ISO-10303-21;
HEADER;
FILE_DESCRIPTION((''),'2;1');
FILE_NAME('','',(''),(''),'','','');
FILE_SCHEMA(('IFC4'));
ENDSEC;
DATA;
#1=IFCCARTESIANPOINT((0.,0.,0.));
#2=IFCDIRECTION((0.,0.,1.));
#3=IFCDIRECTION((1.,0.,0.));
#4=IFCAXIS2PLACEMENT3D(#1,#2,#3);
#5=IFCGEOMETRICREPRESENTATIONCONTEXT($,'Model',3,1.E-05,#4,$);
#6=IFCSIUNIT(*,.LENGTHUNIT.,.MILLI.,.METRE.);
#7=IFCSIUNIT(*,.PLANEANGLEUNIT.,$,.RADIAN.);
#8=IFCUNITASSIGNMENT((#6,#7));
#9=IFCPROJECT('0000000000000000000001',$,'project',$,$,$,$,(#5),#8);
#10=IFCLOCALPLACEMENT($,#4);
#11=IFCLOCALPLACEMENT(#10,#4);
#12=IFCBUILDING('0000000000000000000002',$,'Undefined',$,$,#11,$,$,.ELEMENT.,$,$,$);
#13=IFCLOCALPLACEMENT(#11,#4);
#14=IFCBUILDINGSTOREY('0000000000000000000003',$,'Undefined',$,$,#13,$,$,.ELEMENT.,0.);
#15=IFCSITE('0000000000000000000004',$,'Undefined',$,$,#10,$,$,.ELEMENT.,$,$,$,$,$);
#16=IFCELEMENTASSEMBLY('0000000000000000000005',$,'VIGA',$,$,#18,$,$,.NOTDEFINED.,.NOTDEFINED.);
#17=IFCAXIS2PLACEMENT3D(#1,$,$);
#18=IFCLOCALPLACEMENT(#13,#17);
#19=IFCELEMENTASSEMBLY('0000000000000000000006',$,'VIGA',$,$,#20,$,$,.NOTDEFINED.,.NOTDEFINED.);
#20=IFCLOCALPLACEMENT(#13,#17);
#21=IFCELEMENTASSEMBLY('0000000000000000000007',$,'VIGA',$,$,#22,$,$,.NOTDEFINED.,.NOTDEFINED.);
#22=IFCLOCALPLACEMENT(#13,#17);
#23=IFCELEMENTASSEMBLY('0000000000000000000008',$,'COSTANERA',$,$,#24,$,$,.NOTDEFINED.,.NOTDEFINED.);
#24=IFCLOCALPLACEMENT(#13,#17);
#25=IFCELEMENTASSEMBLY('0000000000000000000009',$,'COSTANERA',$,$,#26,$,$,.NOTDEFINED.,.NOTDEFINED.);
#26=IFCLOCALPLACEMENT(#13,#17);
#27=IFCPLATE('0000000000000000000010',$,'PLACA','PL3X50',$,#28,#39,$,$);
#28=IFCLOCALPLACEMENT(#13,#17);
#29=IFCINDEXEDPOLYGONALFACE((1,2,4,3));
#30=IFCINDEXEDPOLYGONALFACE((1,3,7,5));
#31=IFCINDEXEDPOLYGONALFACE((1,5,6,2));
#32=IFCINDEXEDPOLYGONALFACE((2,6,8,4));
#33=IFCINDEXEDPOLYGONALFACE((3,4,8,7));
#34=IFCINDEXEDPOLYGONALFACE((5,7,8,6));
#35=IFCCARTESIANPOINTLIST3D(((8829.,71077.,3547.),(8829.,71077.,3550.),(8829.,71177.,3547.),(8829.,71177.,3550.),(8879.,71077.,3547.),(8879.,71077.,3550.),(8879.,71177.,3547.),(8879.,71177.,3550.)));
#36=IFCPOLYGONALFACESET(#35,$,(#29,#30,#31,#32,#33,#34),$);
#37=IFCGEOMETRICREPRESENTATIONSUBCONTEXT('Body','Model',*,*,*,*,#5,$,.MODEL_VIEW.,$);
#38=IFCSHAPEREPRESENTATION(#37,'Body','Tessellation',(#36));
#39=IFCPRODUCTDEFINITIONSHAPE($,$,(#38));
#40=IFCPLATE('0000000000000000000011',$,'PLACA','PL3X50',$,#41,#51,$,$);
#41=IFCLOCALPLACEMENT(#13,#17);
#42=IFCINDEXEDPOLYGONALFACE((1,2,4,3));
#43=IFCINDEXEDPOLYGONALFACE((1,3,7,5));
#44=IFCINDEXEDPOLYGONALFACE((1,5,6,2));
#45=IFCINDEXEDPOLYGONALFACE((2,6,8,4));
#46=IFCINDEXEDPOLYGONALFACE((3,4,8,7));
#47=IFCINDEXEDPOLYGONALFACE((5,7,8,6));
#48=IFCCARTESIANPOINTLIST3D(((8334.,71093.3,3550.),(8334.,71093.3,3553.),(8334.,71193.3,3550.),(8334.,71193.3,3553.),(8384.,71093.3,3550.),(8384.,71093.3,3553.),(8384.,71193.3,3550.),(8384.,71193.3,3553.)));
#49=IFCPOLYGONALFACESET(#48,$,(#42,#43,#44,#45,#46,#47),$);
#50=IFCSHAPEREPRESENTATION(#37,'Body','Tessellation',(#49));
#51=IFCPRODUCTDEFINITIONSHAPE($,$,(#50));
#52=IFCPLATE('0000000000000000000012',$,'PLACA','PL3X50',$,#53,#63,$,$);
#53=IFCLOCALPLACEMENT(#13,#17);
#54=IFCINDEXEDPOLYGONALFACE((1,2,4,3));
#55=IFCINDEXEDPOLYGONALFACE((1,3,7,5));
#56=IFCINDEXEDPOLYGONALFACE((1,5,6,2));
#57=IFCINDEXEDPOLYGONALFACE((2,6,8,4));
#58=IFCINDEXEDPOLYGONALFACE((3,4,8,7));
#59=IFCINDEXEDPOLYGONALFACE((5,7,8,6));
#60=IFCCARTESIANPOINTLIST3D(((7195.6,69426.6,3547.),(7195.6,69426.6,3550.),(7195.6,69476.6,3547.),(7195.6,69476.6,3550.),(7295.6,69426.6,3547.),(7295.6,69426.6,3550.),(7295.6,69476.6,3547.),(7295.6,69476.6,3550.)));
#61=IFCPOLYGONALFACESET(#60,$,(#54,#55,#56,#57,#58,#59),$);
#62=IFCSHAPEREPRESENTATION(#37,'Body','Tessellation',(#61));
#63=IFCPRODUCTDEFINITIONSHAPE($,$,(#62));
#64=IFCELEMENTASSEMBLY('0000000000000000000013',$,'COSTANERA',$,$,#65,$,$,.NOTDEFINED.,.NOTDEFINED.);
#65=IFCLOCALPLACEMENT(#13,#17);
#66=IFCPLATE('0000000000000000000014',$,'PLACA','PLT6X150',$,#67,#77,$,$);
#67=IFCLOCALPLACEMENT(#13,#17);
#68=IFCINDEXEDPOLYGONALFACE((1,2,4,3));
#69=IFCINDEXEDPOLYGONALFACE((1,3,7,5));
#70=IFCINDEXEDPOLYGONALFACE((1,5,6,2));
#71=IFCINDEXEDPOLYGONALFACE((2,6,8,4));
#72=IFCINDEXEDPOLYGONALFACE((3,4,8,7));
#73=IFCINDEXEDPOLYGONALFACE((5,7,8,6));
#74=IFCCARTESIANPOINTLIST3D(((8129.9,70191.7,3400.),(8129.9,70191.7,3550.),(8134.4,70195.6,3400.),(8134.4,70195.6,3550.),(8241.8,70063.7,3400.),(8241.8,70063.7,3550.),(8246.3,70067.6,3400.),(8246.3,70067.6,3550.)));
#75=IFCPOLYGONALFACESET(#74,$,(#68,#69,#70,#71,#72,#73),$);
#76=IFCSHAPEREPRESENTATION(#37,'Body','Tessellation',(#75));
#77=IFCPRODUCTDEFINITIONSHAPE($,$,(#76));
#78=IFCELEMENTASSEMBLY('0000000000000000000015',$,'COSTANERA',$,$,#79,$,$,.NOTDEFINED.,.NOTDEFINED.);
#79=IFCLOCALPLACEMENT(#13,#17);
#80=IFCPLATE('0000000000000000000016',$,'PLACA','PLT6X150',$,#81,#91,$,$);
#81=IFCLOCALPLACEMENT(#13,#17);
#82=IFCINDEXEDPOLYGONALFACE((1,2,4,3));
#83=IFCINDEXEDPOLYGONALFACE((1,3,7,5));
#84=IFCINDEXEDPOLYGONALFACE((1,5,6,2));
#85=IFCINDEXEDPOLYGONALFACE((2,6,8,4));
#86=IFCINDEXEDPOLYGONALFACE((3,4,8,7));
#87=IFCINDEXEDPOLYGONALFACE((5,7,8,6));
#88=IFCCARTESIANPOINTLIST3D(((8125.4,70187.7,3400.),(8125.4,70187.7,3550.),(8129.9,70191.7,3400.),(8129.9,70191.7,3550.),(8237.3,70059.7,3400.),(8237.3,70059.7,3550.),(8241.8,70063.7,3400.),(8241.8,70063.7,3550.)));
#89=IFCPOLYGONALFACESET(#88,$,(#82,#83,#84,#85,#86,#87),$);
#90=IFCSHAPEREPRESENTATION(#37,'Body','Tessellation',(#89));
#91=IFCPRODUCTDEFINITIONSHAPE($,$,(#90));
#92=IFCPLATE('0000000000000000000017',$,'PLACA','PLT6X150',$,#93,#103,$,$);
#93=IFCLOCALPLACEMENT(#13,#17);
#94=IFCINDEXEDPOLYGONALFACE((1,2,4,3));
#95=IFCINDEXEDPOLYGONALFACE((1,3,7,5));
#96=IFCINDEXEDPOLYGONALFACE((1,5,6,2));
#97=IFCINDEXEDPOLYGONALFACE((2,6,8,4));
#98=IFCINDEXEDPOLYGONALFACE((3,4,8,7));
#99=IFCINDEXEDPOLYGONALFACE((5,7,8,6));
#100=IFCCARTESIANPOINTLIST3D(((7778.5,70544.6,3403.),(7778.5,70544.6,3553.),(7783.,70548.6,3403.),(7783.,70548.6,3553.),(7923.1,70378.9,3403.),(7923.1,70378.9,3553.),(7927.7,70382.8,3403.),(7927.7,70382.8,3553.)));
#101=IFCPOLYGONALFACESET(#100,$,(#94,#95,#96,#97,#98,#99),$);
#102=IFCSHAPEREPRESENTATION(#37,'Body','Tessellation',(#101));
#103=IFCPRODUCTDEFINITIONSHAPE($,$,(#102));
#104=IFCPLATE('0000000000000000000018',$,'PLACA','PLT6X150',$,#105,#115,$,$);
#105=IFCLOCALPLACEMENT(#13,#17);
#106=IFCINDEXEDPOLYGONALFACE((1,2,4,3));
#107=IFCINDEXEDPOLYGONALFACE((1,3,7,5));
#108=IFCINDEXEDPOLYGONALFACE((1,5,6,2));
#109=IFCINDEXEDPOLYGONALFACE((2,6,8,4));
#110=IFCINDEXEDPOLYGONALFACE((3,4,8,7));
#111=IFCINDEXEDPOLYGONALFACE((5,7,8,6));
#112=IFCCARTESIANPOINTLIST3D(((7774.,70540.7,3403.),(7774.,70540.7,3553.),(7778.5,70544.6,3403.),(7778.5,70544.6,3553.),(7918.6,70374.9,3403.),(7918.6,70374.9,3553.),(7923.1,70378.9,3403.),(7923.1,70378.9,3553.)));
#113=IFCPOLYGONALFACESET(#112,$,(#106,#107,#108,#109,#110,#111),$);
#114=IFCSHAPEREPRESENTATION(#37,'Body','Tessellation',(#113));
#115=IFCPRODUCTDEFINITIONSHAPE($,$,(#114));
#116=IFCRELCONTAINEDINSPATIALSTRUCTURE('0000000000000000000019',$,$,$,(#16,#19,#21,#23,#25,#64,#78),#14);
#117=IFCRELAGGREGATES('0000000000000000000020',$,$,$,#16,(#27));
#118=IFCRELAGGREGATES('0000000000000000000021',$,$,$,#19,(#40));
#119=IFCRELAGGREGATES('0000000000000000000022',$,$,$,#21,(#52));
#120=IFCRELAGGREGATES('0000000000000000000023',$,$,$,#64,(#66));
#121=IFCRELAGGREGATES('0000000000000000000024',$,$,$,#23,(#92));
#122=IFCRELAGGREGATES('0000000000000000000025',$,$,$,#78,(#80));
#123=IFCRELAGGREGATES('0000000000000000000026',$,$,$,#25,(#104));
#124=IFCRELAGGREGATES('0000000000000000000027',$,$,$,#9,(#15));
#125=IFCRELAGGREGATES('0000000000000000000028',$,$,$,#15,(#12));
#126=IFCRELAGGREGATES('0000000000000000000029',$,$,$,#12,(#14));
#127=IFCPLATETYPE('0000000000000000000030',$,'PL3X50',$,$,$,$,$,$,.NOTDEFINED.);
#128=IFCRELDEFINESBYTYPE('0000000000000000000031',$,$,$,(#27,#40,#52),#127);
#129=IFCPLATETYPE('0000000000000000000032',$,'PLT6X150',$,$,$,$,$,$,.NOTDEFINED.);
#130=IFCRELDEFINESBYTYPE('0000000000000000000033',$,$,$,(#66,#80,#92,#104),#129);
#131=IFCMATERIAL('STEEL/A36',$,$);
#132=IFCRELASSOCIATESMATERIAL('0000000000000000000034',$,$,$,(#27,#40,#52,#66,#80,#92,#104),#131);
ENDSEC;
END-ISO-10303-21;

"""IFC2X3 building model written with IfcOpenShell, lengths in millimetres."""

from ifc_helpers import new_model, si_unit, frame, origin_with_axes, place, context, subcontext, project, spatial, polyline, outline, extrude, material, type_object, element, aggregate, save


model = new_model("IFC2X3")

# Units and contexts
model_context = context("Model", 3, precision=1e-05, world=origin_with_axes())
body_context = subcontext(model_context, "Body", "Model", "MODEL_VIEW")
ifc_project = project(units=[si_unit("LENGTHUNIT", "METRE", prefix="MILLI"), si_unit("PLANEANGLEUNIT", "RADIAN")], contexts=[model_context])

# Site, building, storey
site_placement = place(None, origin_with_axes())
site = spatial("IfcSite", under=ifc_project, at=site_placement, Name="Undefined", CompositionType="ELEMENT")
building_placement = place(site_placement, origin_with_axes())
building = spatial("IfcBuilding", under=site, at=building_placement, Name="Undefined", CompositionType="ELEMENT")
storey_placement = place(building_placement, origin_with_axes())
storey = spatial("IfcBuildingStorey", under=building, at=storey_placement, Name="Undefined", CompositionType="ELEMENT", Elevation=0.0)

# Element assemblies
assembly_1_placement = place(storey_placement, origin_with_axes())
assembly_1 = element("IfcElementAssembly", 1, at=assembly_1_placement, inside=storey, Name="VIGA", AssemblyPlace="NOTDEFINED", PredefinedType="NOTDEFINED")
ifc_material_1 = material(Name="STEEL/A36")
assembly_2_placement = place(storey_placement, origin_with_axes())
assembly_2 = element("IfcElementAssembly", 2, at=assembly_2_placement, inside=storey, Name="VIGA", AssemblyPlace="NOTDEFINED", PredefinedType="NOTDEFINED")
assembly_3_placement = place(storey_placement, origin_with_axes())
assembly_3 = element("IfcElementAssembly", 3, at=assembly_3_placement, inside=storey, Name="VIGA", AssemblyPlace="NOTDEFINED", PredefinedType="NOTDEFINED")
assembly_4_placement = place(storey_placement, origin_with_axes())
assembly_4 = element("IfcElementAssembly", 4, at=assembly_4_placement, inside=storey, Name="COSTANERA", AssemblyPlace="NOTDEFINED", PredefinedType="NOTDEFINED")

# Element assembly
assembly_5_placement = place(storey_placement, origin_with_axes())
assembly_5 = element("IfcElementAssembly", 5, at=assembly_5_placement, inside=storey, Name="COSTANERA", AssemblyPlace="NOTDEFINED", PredefinedType="NOTDEFINED")

# Plates
plate_type_1 = type_object("IfcPlateType", Name="PL3X50", PredefinedType="NOTDEFINED")
plate_1_placement = place(assembly_1_placement, frame((8879.0, 71077.0, 3548.5), z_axis=(0.0, 0.0, -1.0), x_axis=(-1.0, 0.0, 0.0)))
plate_1 = element("IfcPlate", 6, at=plate_1_placement, type_object=plate_type_1, material=ifc_material_1, Name="PLACA", Description="PL3X50", context=body_context, shape_type="SweptSolid", body=[
    extrude(outline(polyline([(0.0, 0.0), (50.0, 0.0), (50.0, 100.0), (0.0, 100.0), (0.0, 0.0)])), frame((0.0, 0.0, -1.5), z_axis=(0.0, 0.0, 1.0), x_axis=(1.0, 0.0, 0.0)), (0.0, 0.0, 1.0), 3.0),
])
aggregate(assembly_1, [plate_1])
plate_2_placement = place(assembly_2_placement, frame((8384.0, 71093.3, 3551.5), z_axis=(0.0, 0.0, -1.0), x_axis=(-1.0, 0.0, 0.0)))
plate_2 = element("IfcPlate", 7, at=plate_2_placement, type_object=plate_type_1, material=ifc_material_1, Name="PLACA", Description="PL3X50", context=body_context, shape_type="SweptSolid", body=[
    extrude(outline(polyline([(0.0, 0.0), (50.0, 0.0), (50.0, 100.0), (0.0, 100.0), (0.0, 0.0)])), frame((0.0, 0.0, -1.5), z_axis=(0.0, 0.0, 1.0), x_axis=(1.0, 0.0, 0.0)), (0.0, 0.0, 1.0), 3.0),
])
aggregate(assembly_2, [plate_2])
plate_3_placement = place(assembly_3_placement, frame((7195.6, 69426.6, 3548.5), z_axis=(0.0, 0.0, -1.0), x_axis=(0.0, 1.0, 0.0)))
plate_3 = element("IfcPlate", 8, at=plate_3_placement, type_object=plate_type_1, material=ifc_material_1, Name="PLACA", Description="PL3X50", context=body_context, shape_type="SweptSolid", body=[
    extrude(outline(polyline([(0.0, 0.0), (50.0, 0.0), (50.0, 100.0), (0.0, 100.0), (0.0, 0.0)])), frame((0.0, 0.0, -1.5), z_axis=(0.0, 0.0, 1.0), x_axis=(1.0, 0.0, 0.0)), (0.0, 0.0, 1.0), 3.0),
])
aggregate(assembly_3, [plate_3])

# Element assemblies, plates
assembly_6_placement = place(storey_placement, origin_with_axes())
assembly_6 = element("IfcElementAssembly", 9, at=assembly_6_placement, inside=storey, Name="COSTANERA", AssemblyPlace="NOTDEFINED", PredefinedType="NOTDEFINED")
plate_type_2 = type_object("IfcPlateType", Name="PLT6X150", PredefinedType="NOTDEFINED")
plate_4_placement = place(assembly_6_placement, frame((8132.2, 70193.7, 3550.0), z_axis=(0.752989, 0.658033, 0.0), x_axis=(0.658033, -0.752989, 0.0)))
plate_4 = element("IfcPlate", 10, at=plate_4_placement, type_object=plate_type_2, material=ifc_material_1, Name="PLACA", Description="PLT6X150", context=body_context, shape_type="SweptSolid", body=[
    extrude(outline(polyline([(0.0, 0.0), (170.0, 0.0), (170.0, 150.0), (0.0, 150.0), (0.0, 0.0)])), frame((0.0, 0.0, -3.0), z_axis=(0.0, 0.0, 1.0), x_axis=(1.0, 0.0, 0.0)), (0.0, 0.0, 1.0), 6.0),
])
assembly_7_placement = place(storey_placement, origin_with_axes())
assembly_7 = element("IfcElementAssembly", 11, at=assembly_7_placement, inside=storey, Name="COSTANERA", AssemblyPlace="NOTDEFINED", PredefinedType="NOTDEFINED")
plate_5_placement = place(assembly_7_placement, frame((8127.7, 70189.7, 3550.0), z_axis=(0.752989, 0.658033, 0.0), x_axis=(0.658033, -0.752989, 0.0)))
plate_5 = element("IfcPlate", 12, at=plate_5_placement, type_object=plate_type_2, material=ifc_material_1, Name="PLACA", Description="PLT6X150", context=body_context, shape_type="SweptSolid", body=[
    extrude(outline(polyline([(0.0, 0.0), (170.0, 0.0), (170.0, 150.0), (0.0, 150.0), (0.0, 0.0)])), frame((0.0, 0.0, -3.0), z_axis=(0.0, 0.0, 1.0), x_axis=(1.0, 0.0, 0.0)), (0.0, 0.0, 1.0), 6.0),
])

# Plates
plate_6_placement = place(assembly_4_placement, frame((7780.8, 70546.6, 3553.0), z_axis=(0.753518, 0.657427, 0.0), x_axis=(0.657427, -0.753518, 0.0)))
plate_6 = element("IfcPlate", 13, at=plate_6_placement, type_object=plate_type_2, material=ifc_material_1, Name="PLACA", Description="PLT6X150", context=body_context, shape_type="SweptSolid", body=[
    extrude(outline(polyline([(0.0, 0.0), (220.0, 0.0), (220.0, 150.0), (0.0, 150.0), (0.0, 0.0)])), frame((0.0, 0.0, -3.0), z_axis=(0.0, 0.0, 1.0), x_axis=(1.0, 0.0, 0.0)), (0.0, 0.0, 1.0), 6.0),
])
plate_7_placement = place(assembly_5_placement, frame((7776.3, 70542.7, 3553.0), z_axis=(0.753518, 0.657427, 0.0), x_axis=(0.657427, -0.753518, 0.0)))
plate_7 = element("IfcPlate", 14, at=plate_7_placement, type_object=plate_type_2, material=ifc_material_1, Name="PLACA", Description="PLT6X150", context=body_context, shape_type="SweptSolid", body=[
    extrude(outline(polyline([(0.0, 0.0), (220.0, 0.0), (220.0, 150.0), (0.0, 150.0), (0.0, 0.0)])), frame((0.0, 0.0, -3.0), z_axis=(0.0, 0.0, 1.0), x_axis=(1.0, 0.0, 0.0)), (0.0, 0.0, 1.0), 6.0),
])

aggregate(assembly_6, [plate_4])
aggregate(assembly_4, [plate_6])
aggregate(assembly_7, [plate_5])
aggregate(assembly_5, [plate_7])

save(model, "model.ifc")
